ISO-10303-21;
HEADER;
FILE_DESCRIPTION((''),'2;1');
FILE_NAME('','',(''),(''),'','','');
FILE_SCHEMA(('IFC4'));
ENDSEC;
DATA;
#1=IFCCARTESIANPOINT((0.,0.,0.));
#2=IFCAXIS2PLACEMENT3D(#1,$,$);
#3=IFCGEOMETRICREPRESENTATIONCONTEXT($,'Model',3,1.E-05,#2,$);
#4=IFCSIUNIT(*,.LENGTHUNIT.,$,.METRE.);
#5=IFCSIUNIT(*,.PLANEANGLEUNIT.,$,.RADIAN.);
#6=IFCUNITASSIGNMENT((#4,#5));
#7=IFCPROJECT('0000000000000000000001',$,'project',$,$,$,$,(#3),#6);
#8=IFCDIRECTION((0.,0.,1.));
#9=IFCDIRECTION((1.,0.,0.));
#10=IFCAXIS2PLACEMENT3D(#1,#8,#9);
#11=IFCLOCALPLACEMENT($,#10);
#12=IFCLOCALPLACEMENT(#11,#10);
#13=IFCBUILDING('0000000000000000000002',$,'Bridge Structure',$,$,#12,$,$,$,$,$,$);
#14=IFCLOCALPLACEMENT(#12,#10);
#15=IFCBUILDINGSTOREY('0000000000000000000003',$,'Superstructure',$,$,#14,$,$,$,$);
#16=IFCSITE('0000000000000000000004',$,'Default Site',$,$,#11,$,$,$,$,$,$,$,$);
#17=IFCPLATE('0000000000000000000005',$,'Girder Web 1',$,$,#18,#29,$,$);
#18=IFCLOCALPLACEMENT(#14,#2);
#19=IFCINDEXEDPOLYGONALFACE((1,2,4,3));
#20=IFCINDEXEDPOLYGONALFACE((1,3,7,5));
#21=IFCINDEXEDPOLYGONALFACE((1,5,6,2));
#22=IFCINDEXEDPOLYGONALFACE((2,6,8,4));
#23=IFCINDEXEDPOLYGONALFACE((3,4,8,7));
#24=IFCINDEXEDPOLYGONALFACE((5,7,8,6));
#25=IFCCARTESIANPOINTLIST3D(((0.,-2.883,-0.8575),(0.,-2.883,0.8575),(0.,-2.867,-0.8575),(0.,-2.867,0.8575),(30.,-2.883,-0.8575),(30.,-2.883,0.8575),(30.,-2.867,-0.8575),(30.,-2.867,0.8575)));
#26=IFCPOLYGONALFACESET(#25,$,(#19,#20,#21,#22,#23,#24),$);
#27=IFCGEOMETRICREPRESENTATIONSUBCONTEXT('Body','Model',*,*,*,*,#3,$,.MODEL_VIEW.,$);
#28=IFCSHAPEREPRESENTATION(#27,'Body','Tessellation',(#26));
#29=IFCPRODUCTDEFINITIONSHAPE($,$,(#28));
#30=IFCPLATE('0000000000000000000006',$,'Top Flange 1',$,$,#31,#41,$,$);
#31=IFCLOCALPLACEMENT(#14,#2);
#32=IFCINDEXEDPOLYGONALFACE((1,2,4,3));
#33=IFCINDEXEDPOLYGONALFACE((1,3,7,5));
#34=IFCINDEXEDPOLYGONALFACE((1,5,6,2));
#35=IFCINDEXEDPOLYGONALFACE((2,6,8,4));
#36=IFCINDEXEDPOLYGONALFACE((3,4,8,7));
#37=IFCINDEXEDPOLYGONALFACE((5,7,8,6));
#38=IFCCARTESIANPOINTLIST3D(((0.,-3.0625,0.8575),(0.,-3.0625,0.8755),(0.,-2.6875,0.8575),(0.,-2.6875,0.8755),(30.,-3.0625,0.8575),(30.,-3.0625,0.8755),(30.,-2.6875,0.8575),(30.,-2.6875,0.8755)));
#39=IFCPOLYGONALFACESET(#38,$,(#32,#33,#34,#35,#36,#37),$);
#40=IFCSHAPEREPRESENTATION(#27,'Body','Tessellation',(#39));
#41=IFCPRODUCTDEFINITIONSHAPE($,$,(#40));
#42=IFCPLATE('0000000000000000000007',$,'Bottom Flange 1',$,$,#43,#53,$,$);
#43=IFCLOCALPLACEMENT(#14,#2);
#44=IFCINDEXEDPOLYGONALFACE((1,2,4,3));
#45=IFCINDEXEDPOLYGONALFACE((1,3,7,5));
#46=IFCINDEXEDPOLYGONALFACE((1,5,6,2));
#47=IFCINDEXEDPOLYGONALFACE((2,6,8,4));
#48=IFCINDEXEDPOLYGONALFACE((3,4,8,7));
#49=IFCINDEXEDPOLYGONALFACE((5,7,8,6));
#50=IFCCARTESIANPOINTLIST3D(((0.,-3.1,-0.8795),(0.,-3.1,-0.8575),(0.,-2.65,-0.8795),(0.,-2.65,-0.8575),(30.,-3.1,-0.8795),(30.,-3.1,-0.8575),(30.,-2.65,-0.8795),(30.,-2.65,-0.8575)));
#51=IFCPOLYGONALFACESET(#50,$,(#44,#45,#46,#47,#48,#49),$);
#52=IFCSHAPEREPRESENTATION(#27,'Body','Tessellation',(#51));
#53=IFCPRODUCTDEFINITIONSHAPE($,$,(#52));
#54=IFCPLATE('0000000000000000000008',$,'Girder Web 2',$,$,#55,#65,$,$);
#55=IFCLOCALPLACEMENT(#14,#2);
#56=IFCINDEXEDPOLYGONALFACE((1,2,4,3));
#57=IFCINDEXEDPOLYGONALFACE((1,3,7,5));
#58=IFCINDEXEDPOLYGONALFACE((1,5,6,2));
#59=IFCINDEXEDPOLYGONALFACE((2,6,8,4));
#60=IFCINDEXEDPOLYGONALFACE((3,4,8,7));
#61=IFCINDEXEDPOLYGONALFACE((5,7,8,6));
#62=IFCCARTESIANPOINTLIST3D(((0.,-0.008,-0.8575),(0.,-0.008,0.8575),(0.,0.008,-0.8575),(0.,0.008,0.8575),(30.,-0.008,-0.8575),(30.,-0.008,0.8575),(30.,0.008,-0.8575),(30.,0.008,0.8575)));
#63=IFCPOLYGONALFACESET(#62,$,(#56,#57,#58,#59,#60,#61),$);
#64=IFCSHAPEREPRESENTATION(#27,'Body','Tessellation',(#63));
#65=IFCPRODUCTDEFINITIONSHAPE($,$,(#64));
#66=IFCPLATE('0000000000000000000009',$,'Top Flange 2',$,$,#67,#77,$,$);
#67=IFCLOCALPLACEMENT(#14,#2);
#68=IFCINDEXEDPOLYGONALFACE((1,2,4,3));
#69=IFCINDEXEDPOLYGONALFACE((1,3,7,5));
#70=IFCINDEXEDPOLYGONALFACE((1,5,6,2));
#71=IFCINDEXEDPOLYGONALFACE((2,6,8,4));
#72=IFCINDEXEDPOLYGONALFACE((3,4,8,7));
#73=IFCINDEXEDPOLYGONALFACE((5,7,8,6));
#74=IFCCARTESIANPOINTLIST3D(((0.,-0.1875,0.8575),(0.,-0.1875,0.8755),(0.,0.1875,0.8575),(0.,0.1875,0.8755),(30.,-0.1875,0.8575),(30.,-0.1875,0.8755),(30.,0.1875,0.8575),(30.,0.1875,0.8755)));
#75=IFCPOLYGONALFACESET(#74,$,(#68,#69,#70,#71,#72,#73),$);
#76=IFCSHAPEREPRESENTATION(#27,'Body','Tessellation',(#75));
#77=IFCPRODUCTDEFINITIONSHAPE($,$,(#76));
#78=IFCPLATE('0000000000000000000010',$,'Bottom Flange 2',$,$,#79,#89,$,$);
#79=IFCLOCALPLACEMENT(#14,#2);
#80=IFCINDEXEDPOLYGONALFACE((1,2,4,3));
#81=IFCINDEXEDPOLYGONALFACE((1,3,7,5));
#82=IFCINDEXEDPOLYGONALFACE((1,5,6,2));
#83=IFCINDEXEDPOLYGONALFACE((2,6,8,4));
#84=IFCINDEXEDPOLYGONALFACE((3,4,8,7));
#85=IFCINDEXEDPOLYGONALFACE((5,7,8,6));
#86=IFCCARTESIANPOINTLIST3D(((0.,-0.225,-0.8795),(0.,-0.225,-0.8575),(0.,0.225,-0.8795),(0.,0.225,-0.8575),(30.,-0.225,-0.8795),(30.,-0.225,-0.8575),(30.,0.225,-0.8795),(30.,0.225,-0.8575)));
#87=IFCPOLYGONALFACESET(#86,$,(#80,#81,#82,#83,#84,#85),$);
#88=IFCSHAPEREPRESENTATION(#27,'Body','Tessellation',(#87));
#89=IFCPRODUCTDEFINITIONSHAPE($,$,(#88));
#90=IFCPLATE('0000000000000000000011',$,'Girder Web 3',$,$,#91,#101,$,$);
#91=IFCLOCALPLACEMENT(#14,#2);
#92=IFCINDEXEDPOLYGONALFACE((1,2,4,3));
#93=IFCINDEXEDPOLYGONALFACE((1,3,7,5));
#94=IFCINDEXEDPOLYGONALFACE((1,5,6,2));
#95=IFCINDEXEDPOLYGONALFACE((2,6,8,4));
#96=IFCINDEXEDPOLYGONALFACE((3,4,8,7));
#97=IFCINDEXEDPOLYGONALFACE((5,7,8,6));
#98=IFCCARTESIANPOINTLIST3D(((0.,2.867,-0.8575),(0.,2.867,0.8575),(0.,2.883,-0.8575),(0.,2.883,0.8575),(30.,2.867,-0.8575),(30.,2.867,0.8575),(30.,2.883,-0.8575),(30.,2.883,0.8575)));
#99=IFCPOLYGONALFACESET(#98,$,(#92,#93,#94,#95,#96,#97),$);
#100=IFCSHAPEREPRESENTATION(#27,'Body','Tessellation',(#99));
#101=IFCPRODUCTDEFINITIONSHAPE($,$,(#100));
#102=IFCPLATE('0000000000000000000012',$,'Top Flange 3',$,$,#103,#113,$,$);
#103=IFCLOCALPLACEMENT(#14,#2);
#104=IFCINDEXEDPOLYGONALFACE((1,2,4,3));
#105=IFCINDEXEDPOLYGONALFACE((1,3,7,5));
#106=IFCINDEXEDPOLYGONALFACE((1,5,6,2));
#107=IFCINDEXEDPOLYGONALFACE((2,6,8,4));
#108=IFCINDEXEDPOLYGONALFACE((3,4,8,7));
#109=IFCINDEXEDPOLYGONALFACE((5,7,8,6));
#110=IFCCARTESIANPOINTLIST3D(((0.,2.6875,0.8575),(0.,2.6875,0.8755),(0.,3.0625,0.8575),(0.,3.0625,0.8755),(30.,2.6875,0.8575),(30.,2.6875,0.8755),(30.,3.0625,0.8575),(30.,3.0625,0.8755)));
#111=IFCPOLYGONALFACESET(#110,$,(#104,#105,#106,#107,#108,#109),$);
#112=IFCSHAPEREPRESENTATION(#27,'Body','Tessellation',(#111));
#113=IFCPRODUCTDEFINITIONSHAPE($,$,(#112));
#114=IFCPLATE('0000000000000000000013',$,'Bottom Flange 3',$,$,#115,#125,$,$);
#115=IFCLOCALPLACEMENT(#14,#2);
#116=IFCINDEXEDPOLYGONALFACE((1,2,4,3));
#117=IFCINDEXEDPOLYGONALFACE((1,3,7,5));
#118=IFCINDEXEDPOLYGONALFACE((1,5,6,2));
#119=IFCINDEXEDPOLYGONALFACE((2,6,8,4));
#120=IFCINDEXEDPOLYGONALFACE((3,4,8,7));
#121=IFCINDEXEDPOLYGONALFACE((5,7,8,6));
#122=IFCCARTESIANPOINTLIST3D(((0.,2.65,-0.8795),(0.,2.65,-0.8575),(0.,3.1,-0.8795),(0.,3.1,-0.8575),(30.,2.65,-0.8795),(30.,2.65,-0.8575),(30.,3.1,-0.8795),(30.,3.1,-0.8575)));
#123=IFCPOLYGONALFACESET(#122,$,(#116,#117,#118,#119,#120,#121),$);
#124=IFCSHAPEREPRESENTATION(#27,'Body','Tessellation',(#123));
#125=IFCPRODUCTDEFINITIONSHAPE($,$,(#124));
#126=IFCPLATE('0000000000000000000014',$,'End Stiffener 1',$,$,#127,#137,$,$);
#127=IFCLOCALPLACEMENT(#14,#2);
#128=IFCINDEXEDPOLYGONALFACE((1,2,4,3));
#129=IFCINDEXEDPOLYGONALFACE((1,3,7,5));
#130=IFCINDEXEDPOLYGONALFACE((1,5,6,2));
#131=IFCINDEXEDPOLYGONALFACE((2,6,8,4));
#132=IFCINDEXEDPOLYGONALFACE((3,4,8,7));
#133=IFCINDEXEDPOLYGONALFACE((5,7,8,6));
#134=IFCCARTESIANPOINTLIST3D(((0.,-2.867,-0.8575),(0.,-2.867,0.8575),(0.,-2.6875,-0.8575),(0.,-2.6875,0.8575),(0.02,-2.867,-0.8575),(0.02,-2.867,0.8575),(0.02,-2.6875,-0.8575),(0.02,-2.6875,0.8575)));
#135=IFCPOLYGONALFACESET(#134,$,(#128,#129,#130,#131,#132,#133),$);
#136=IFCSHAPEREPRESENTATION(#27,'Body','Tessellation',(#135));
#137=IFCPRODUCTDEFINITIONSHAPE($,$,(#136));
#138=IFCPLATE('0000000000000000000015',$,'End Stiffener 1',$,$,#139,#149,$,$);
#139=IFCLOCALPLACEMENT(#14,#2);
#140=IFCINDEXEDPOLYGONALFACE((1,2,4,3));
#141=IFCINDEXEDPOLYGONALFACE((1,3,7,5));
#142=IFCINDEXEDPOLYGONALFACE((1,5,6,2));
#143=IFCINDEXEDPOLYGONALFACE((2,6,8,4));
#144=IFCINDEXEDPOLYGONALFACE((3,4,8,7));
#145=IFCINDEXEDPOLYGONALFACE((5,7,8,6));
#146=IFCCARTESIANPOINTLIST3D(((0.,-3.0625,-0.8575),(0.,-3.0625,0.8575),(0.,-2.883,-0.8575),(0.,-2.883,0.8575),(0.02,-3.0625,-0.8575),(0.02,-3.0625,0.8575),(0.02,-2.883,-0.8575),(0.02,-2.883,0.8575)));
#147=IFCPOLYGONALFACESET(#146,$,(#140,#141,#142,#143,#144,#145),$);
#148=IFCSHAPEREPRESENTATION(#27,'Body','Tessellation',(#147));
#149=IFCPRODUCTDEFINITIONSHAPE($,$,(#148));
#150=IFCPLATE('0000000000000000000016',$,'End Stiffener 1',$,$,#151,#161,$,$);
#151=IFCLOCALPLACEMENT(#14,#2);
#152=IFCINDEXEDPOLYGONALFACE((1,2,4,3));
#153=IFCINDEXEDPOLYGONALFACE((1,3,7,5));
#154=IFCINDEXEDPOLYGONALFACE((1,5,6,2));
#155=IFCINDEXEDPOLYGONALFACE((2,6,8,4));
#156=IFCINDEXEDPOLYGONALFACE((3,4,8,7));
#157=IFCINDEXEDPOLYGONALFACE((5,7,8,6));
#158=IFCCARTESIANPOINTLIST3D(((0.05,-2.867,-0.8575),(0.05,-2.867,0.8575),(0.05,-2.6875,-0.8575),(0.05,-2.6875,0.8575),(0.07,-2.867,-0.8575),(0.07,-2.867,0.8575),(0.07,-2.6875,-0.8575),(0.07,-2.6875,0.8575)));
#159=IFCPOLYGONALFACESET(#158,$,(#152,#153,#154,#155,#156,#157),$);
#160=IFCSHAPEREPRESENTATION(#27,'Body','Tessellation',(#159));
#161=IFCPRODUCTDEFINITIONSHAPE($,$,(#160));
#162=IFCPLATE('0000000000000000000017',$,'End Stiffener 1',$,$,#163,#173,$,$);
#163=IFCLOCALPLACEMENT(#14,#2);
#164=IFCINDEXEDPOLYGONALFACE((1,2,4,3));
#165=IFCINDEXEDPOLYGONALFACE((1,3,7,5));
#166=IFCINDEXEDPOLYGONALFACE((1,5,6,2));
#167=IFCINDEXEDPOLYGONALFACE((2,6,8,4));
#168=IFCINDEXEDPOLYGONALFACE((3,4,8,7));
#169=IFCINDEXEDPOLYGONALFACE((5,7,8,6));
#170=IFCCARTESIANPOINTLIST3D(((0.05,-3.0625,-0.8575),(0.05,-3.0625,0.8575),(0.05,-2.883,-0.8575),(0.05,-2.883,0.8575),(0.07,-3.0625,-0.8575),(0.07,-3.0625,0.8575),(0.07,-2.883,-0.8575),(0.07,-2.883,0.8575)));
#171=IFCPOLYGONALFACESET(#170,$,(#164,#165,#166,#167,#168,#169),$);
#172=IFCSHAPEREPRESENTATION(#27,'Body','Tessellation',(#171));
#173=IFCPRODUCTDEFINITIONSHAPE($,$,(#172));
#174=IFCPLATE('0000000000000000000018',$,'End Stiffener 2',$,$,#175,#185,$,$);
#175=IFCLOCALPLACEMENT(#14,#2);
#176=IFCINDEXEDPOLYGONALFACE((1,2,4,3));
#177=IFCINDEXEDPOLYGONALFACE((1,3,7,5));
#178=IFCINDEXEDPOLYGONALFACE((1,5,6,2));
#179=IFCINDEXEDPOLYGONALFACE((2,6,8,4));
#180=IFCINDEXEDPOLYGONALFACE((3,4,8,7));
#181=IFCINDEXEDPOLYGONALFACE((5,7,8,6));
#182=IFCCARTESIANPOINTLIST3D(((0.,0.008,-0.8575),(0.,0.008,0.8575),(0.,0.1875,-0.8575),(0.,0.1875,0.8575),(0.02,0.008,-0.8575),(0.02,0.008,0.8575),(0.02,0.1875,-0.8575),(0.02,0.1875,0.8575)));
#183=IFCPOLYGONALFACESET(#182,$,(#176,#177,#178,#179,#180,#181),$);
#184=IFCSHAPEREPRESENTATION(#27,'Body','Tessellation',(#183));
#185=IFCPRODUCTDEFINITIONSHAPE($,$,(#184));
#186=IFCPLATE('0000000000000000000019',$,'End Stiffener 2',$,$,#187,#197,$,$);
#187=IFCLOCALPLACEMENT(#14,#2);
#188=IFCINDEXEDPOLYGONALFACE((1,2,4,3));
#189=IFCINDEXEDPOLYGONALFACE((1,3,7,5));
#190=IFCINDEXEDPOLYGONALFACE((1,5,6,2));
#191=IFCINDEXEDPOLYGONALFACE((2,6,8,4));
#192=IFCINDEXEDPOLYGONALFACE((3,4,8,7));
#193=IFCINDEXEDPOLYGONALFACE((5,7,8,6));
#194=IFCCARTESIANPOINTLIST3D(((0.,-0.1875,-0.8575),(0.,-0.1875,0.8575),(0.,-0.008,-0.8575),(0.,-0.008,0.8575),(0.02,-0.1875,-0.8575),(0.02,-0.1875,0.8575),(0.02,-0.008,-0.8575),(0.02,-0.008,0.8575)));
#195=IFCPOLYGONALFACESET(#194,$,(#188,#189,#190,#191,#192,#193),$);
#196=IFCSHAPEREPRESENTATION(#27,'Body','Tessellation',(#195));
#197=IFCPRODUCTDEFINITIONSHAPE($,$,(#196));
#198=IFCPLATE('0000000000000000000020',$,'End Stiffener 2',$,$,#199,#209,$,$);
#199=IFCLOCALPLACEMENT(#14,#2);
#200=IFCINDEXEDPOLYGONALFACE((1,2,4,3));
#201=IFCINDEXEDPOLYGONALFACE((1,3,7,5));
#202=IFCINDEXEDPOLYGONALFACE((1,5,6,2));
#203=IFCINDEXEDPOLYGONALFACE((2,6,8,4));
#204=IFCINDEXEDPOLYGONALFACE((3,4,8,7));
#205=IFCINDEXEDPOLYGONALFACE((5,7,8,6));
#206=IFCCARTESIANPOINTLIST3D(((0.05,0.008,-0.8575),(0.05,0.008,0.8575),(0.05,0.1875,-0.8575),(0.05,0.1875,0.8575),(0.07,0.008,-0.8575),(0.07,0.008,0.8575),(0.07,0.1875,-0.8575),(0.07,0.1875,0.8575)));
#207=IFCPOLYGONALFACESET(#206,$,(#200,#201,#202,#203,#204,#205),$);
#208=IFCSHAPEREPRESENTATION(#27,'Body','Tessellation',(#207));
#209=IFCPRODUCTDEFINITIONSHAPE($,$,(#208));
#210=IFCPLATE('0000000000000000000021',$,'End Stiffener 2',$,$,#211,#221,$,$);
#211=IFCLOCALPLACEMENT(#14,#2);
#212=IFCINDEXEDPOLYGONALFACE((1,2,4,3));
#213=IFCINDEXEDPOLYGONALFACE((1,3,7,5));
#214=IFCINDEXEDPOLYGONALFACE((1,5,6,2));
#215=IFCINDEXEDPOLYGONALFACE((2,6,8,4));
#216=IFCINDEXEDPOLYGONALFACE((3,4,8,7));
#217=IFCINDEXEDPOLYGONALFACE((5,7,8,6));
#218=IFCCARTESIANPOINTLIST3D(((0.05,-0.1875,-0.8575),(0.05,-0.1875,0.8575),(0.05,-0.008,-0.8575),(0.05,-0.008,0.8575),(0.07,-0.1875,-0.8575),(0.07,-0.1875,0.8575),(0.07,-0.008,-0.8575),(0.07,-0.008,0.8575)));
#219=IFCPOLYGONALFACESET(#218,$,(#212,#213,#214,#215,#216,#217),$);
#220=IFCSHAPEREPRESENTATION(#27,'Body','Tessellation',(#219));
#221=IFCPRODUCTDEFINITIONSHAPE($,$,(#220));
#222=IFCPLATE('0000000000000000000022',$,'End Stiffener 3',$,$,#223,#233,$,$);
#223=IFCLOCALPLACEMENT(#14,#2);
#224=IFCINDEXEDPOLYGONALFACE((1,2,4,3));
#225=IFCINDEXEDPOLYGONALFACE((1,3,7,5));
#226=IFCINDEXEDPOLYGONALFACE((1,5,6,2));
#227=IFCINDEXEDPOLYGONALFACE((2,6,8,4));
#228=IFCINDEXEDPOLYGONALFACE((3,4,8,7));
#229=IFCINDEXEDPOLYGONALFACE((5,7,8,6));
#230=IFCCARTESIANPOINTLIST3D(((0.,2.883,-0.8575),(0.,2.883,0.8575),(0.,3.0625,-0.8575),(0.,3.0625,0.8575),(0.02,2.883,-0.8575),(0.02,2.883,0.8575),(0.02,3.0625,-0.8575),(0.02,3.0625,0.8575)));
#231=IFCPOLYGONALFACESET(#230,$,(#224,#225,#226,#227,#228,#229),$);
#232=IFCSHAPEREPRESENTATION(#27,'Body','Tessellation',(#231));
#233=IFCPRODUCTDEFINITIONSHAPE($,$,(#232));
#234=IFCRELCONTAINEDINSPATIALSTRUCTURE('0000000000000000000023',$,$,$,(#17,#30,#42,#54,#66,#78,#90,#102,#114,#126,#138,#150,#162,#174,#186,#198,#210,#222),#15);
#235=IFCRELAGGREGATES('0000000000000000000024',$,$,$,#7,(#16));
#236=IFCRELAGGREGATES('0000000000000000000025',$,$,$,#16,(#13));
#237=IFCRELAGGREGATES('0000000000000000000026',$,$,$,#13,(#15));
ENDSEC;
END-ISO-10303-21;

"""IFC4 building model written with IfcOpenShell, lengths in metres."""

from ifc_helpers import new_model, si_unit, frame, origin, origin_with_axes, origin_2d_with_axis, place, context, subcontext, project, spatial, rectangle, extrude, element, save


model = new_model("IFC4")

# Units and contexts
model_context = context("Model", 3, precision=1e-05, world=origin())
body_context = subcontext(model_context, "Body", "Model", "MODEL_VIEW")
ifc_project = project(units=[si_unit("LENGTHUNIT", "METRE"), si_unit("PLANEANGLEUNIT", "RADIAN")], contexts=[model_context])

# Site, building, storey
site_placement = place(None, origin_with_axes())
site = spatial("IfcSite", under=ifc_project, at=site_placement, Name="Default Site")
building_placement = place(site_placement, origin_with_axes())
building = spatial("IfcBuilding", under=site, at=building_placement, Name="Bridge Structure")
storey_placement = place(building_placement, origin_with_axes())
storey = spatial("IfcBuildingStorey", under=building, at=storey_placement, Name="Superstructure")

# Plates
plate_1_placement = place(storey_placement, frame((0.0, -2.875, 0.0), z_axis=(1.0, 0.0, 0.0), x_axis=(0.0, 1.0, 0.0)))
element("IfcPlate", 1, at=plate_1_placement, inside=storey, Name="Girder Web 1", context=body_context, shape_type="SweptSolid", body=[
    extrude(rectangle(XDim=0.016, YDim=1.715, at=origin_2d_with_axis()), origin_with_axes(), (0.0, 0.0, 1.0), 30.0),
])
plate_2_placement = place(storey_placement, frame((0.0, -2.875, 0.8665), z_axis=(1.0, 0.0, 0.0), x_axis=(0.0, 1.0, 0.0)))
element("IfcPlate", 2, at=plate_2_placement, inside=storey, Name="Top Flange 1", context=body_context, shape_type="SweptSolid", body=[
    extrude(rectangle(XDim=0.375, YDim=0.018, at=origin_2d_with_axis()), origin_with_axes(), (0.0, 0.0, 1.0), 30.0),
])
plate_3_placement = place(storey_placement, frame((0.0, -2.875, -0.8685), z_axis=(1.0, 0.0, 0.0), x_axis=(0.0, 1.0, 0.0)))
element("IfcPlate", 3, at=plate_3_placement, inside=storey, Name="Bottom Flange 1", context=body_context, shape_type="SweptSolid", body=[
    extrude(rectangle(XDim=0.45, YDim=0.022, at=origin_2d_with_axis()), origin_with_axes(), (0.0, 0.0, 1.0), 30.0),
])
plate_4_placement = place(storey_placement, frame((0.0, 0.0, 0.0), z_axis=(1.0, 0.0, 0.0), x_axis=(0.0, 1.0, 0.0)))
element("IfcPlate", 4, at=plate_4_placement, inside=storey, Name="Girder Web 2", context=body_context, shape_type="SweptSolid", body=[
    extrude(rectangle(XDim=0.016, YDim=1.715, at=origin_2d_with_axis()), origin_with_axes(), (0.0, 0.0, 1.0), 30.0),
])
plate_5_placement = place(storey_placement, frame((0.0, 0.0, 0.8665), z_axis=(1.0, 0.0, 0.0), x_axis=(0.0, 1.0, 0.0)))
element("IfcPlate", 5, at=plate_5_placement, inside=storey, Name="Top Flange 2", context=body_context, shape_type="SweptSolid", body=[
    extrude(rectangle(XDim=0.375, YDim=0.018, at=origin_2d_with_axis()), origin_with_axes(), (0.0, 0.0, 1.0), 30.0),
])
plate_6_placement = place(storey_placement, frame((0.0, 0.0, -0.8685), z_axis=(1.0, 0.0, 0.0), x_axis=(0.0, 1.0, 0.0)))
element("IfcPlate", 6, at=plate_6_placement, inside=storey, Name="Bottom Flange 2", context=body_context, shape_type="SweptSolid", body=[
    extrude(rectangle(XDim=0.45, YDim=0.022, at=origin_2d_with_axis()), origin_with_axes(), (0.0, 0.0, 1.0), 30.0),
])
plate_7_placement = place(storey_placement, frame((0.0, 2.875, 0.0), z_axis=(1.0, 0.0, 0.0), x_axis=(0.0, 1.0, 0.0)))
element("IfcPlate", 7, at=plate_7_placement, inside=storey, Name="Girder Web 3", context=body_context, shape_type="SweptSolid", body=[
    extrude(rectangle(XDim=0.016, YDim=1.715, at=origin_2d_with_axis()), origin_with_axes(), (0.0, 0.0, 1.0), 30.0),
])
plate_8_placement = place(storey_placement, frame((0.0, 2.875, 0.8665), z_axis=(1.0, 0.0, 0.0), x_axis=(0.0, 1.0, 0.0)))
element("IfcPlate", 8, at=plate_8_placement, inside=storey, Name="Top Flange 3", context=body_context, shape_type="SweptSolid", body=[
    extrude(rectangle(XDim=0.375, YDim=0.018, at=origin_2d_with_axis()), origin_with_axes(), (0.0, 0.0, 1.0), 30.0),
])
plate_9_placement = place(storey_placement, frame((0.0, 2.875, -0.8685), z_axis=(1.0, 0.0, 0.0), x_axis=(0.0, 1.0, 0.0)))
element("IfcPlate", 9, at=plate_9_placement, inside=storey, Name="Bottom Flange 3", context=body_context, shape_type="SweptSolid", body=[
    extrude(rectangle(XDim=0.45, YDim=0.022, at=origin_2d_with_axis()), origin_with_axes(), (0.0, 0.0, 1.0), 30.0),
])
for number, where, z_axis, x_axis, name in (
    (10, (0.01, -2.7772, -0.8575), (0.0, 0.0, 1.0), (1.0, 0.0, 0.0), "End Stiffener 1"),
    (11, (0.01, -2.9728, -0.8575), (0.0, 0.0, 1.0), (1.0, 0.0, 0.0), "End Stiffener 1"),
    (12, (0.06, -2.7772, -0.8575), (0.0, 0.0, 1.0), (1.0, 0.0, 0.0), "End Stiffener 1"),
    (13, (0.06, -2.9728, -0.8575), (0.0, 0.0, 1.0), (1.0, 0.0, 0.0), "End Stiffener 1"),
    (14, (0.01, 0.0978, -0.8575), (0.0, 0.0, 1.0), (1.0, 0.0, 0.0), "End Stiffener 2"),
    (15, (0.01, -0.0978, -0.8575), (0.0, 0.0, 1.0), (1.0, 0.0, 0.0), "End Stiffener 2"),
    (16, (0.06, 0.0978, -0.8575), (0.0, 0.0, 1.0), (1.0, 0.0, 0.0), "End Stiffener 2"),
    (17, (0.06, -0.0978, -0.8575), (0.0, 0.0, 1.0), (1.0, 0.0, 0.0), "End Stiffener 2"),
    (18, (0.01, 2.9728, -0.8575), (0.0, 0.0, 1.0), (1.0, 0.0, 0.0), "End Stiffener 3"),
):
    element("IfcPlate", number, at=place(storey_placement, frame(where, z_axis=z_axis, x_axis=x_axis)), inside=storey, Name=name, context=body_context, shape_type="SweptSolid", body=[
        extrude(rectangle(XDim=0.02, YDim=0.1795, at=origin_2d_with_axis()), origin_with_axes(), (0.0, 0.0, 1.0), 1.715),
    ])

save(model, "model.ifc")
